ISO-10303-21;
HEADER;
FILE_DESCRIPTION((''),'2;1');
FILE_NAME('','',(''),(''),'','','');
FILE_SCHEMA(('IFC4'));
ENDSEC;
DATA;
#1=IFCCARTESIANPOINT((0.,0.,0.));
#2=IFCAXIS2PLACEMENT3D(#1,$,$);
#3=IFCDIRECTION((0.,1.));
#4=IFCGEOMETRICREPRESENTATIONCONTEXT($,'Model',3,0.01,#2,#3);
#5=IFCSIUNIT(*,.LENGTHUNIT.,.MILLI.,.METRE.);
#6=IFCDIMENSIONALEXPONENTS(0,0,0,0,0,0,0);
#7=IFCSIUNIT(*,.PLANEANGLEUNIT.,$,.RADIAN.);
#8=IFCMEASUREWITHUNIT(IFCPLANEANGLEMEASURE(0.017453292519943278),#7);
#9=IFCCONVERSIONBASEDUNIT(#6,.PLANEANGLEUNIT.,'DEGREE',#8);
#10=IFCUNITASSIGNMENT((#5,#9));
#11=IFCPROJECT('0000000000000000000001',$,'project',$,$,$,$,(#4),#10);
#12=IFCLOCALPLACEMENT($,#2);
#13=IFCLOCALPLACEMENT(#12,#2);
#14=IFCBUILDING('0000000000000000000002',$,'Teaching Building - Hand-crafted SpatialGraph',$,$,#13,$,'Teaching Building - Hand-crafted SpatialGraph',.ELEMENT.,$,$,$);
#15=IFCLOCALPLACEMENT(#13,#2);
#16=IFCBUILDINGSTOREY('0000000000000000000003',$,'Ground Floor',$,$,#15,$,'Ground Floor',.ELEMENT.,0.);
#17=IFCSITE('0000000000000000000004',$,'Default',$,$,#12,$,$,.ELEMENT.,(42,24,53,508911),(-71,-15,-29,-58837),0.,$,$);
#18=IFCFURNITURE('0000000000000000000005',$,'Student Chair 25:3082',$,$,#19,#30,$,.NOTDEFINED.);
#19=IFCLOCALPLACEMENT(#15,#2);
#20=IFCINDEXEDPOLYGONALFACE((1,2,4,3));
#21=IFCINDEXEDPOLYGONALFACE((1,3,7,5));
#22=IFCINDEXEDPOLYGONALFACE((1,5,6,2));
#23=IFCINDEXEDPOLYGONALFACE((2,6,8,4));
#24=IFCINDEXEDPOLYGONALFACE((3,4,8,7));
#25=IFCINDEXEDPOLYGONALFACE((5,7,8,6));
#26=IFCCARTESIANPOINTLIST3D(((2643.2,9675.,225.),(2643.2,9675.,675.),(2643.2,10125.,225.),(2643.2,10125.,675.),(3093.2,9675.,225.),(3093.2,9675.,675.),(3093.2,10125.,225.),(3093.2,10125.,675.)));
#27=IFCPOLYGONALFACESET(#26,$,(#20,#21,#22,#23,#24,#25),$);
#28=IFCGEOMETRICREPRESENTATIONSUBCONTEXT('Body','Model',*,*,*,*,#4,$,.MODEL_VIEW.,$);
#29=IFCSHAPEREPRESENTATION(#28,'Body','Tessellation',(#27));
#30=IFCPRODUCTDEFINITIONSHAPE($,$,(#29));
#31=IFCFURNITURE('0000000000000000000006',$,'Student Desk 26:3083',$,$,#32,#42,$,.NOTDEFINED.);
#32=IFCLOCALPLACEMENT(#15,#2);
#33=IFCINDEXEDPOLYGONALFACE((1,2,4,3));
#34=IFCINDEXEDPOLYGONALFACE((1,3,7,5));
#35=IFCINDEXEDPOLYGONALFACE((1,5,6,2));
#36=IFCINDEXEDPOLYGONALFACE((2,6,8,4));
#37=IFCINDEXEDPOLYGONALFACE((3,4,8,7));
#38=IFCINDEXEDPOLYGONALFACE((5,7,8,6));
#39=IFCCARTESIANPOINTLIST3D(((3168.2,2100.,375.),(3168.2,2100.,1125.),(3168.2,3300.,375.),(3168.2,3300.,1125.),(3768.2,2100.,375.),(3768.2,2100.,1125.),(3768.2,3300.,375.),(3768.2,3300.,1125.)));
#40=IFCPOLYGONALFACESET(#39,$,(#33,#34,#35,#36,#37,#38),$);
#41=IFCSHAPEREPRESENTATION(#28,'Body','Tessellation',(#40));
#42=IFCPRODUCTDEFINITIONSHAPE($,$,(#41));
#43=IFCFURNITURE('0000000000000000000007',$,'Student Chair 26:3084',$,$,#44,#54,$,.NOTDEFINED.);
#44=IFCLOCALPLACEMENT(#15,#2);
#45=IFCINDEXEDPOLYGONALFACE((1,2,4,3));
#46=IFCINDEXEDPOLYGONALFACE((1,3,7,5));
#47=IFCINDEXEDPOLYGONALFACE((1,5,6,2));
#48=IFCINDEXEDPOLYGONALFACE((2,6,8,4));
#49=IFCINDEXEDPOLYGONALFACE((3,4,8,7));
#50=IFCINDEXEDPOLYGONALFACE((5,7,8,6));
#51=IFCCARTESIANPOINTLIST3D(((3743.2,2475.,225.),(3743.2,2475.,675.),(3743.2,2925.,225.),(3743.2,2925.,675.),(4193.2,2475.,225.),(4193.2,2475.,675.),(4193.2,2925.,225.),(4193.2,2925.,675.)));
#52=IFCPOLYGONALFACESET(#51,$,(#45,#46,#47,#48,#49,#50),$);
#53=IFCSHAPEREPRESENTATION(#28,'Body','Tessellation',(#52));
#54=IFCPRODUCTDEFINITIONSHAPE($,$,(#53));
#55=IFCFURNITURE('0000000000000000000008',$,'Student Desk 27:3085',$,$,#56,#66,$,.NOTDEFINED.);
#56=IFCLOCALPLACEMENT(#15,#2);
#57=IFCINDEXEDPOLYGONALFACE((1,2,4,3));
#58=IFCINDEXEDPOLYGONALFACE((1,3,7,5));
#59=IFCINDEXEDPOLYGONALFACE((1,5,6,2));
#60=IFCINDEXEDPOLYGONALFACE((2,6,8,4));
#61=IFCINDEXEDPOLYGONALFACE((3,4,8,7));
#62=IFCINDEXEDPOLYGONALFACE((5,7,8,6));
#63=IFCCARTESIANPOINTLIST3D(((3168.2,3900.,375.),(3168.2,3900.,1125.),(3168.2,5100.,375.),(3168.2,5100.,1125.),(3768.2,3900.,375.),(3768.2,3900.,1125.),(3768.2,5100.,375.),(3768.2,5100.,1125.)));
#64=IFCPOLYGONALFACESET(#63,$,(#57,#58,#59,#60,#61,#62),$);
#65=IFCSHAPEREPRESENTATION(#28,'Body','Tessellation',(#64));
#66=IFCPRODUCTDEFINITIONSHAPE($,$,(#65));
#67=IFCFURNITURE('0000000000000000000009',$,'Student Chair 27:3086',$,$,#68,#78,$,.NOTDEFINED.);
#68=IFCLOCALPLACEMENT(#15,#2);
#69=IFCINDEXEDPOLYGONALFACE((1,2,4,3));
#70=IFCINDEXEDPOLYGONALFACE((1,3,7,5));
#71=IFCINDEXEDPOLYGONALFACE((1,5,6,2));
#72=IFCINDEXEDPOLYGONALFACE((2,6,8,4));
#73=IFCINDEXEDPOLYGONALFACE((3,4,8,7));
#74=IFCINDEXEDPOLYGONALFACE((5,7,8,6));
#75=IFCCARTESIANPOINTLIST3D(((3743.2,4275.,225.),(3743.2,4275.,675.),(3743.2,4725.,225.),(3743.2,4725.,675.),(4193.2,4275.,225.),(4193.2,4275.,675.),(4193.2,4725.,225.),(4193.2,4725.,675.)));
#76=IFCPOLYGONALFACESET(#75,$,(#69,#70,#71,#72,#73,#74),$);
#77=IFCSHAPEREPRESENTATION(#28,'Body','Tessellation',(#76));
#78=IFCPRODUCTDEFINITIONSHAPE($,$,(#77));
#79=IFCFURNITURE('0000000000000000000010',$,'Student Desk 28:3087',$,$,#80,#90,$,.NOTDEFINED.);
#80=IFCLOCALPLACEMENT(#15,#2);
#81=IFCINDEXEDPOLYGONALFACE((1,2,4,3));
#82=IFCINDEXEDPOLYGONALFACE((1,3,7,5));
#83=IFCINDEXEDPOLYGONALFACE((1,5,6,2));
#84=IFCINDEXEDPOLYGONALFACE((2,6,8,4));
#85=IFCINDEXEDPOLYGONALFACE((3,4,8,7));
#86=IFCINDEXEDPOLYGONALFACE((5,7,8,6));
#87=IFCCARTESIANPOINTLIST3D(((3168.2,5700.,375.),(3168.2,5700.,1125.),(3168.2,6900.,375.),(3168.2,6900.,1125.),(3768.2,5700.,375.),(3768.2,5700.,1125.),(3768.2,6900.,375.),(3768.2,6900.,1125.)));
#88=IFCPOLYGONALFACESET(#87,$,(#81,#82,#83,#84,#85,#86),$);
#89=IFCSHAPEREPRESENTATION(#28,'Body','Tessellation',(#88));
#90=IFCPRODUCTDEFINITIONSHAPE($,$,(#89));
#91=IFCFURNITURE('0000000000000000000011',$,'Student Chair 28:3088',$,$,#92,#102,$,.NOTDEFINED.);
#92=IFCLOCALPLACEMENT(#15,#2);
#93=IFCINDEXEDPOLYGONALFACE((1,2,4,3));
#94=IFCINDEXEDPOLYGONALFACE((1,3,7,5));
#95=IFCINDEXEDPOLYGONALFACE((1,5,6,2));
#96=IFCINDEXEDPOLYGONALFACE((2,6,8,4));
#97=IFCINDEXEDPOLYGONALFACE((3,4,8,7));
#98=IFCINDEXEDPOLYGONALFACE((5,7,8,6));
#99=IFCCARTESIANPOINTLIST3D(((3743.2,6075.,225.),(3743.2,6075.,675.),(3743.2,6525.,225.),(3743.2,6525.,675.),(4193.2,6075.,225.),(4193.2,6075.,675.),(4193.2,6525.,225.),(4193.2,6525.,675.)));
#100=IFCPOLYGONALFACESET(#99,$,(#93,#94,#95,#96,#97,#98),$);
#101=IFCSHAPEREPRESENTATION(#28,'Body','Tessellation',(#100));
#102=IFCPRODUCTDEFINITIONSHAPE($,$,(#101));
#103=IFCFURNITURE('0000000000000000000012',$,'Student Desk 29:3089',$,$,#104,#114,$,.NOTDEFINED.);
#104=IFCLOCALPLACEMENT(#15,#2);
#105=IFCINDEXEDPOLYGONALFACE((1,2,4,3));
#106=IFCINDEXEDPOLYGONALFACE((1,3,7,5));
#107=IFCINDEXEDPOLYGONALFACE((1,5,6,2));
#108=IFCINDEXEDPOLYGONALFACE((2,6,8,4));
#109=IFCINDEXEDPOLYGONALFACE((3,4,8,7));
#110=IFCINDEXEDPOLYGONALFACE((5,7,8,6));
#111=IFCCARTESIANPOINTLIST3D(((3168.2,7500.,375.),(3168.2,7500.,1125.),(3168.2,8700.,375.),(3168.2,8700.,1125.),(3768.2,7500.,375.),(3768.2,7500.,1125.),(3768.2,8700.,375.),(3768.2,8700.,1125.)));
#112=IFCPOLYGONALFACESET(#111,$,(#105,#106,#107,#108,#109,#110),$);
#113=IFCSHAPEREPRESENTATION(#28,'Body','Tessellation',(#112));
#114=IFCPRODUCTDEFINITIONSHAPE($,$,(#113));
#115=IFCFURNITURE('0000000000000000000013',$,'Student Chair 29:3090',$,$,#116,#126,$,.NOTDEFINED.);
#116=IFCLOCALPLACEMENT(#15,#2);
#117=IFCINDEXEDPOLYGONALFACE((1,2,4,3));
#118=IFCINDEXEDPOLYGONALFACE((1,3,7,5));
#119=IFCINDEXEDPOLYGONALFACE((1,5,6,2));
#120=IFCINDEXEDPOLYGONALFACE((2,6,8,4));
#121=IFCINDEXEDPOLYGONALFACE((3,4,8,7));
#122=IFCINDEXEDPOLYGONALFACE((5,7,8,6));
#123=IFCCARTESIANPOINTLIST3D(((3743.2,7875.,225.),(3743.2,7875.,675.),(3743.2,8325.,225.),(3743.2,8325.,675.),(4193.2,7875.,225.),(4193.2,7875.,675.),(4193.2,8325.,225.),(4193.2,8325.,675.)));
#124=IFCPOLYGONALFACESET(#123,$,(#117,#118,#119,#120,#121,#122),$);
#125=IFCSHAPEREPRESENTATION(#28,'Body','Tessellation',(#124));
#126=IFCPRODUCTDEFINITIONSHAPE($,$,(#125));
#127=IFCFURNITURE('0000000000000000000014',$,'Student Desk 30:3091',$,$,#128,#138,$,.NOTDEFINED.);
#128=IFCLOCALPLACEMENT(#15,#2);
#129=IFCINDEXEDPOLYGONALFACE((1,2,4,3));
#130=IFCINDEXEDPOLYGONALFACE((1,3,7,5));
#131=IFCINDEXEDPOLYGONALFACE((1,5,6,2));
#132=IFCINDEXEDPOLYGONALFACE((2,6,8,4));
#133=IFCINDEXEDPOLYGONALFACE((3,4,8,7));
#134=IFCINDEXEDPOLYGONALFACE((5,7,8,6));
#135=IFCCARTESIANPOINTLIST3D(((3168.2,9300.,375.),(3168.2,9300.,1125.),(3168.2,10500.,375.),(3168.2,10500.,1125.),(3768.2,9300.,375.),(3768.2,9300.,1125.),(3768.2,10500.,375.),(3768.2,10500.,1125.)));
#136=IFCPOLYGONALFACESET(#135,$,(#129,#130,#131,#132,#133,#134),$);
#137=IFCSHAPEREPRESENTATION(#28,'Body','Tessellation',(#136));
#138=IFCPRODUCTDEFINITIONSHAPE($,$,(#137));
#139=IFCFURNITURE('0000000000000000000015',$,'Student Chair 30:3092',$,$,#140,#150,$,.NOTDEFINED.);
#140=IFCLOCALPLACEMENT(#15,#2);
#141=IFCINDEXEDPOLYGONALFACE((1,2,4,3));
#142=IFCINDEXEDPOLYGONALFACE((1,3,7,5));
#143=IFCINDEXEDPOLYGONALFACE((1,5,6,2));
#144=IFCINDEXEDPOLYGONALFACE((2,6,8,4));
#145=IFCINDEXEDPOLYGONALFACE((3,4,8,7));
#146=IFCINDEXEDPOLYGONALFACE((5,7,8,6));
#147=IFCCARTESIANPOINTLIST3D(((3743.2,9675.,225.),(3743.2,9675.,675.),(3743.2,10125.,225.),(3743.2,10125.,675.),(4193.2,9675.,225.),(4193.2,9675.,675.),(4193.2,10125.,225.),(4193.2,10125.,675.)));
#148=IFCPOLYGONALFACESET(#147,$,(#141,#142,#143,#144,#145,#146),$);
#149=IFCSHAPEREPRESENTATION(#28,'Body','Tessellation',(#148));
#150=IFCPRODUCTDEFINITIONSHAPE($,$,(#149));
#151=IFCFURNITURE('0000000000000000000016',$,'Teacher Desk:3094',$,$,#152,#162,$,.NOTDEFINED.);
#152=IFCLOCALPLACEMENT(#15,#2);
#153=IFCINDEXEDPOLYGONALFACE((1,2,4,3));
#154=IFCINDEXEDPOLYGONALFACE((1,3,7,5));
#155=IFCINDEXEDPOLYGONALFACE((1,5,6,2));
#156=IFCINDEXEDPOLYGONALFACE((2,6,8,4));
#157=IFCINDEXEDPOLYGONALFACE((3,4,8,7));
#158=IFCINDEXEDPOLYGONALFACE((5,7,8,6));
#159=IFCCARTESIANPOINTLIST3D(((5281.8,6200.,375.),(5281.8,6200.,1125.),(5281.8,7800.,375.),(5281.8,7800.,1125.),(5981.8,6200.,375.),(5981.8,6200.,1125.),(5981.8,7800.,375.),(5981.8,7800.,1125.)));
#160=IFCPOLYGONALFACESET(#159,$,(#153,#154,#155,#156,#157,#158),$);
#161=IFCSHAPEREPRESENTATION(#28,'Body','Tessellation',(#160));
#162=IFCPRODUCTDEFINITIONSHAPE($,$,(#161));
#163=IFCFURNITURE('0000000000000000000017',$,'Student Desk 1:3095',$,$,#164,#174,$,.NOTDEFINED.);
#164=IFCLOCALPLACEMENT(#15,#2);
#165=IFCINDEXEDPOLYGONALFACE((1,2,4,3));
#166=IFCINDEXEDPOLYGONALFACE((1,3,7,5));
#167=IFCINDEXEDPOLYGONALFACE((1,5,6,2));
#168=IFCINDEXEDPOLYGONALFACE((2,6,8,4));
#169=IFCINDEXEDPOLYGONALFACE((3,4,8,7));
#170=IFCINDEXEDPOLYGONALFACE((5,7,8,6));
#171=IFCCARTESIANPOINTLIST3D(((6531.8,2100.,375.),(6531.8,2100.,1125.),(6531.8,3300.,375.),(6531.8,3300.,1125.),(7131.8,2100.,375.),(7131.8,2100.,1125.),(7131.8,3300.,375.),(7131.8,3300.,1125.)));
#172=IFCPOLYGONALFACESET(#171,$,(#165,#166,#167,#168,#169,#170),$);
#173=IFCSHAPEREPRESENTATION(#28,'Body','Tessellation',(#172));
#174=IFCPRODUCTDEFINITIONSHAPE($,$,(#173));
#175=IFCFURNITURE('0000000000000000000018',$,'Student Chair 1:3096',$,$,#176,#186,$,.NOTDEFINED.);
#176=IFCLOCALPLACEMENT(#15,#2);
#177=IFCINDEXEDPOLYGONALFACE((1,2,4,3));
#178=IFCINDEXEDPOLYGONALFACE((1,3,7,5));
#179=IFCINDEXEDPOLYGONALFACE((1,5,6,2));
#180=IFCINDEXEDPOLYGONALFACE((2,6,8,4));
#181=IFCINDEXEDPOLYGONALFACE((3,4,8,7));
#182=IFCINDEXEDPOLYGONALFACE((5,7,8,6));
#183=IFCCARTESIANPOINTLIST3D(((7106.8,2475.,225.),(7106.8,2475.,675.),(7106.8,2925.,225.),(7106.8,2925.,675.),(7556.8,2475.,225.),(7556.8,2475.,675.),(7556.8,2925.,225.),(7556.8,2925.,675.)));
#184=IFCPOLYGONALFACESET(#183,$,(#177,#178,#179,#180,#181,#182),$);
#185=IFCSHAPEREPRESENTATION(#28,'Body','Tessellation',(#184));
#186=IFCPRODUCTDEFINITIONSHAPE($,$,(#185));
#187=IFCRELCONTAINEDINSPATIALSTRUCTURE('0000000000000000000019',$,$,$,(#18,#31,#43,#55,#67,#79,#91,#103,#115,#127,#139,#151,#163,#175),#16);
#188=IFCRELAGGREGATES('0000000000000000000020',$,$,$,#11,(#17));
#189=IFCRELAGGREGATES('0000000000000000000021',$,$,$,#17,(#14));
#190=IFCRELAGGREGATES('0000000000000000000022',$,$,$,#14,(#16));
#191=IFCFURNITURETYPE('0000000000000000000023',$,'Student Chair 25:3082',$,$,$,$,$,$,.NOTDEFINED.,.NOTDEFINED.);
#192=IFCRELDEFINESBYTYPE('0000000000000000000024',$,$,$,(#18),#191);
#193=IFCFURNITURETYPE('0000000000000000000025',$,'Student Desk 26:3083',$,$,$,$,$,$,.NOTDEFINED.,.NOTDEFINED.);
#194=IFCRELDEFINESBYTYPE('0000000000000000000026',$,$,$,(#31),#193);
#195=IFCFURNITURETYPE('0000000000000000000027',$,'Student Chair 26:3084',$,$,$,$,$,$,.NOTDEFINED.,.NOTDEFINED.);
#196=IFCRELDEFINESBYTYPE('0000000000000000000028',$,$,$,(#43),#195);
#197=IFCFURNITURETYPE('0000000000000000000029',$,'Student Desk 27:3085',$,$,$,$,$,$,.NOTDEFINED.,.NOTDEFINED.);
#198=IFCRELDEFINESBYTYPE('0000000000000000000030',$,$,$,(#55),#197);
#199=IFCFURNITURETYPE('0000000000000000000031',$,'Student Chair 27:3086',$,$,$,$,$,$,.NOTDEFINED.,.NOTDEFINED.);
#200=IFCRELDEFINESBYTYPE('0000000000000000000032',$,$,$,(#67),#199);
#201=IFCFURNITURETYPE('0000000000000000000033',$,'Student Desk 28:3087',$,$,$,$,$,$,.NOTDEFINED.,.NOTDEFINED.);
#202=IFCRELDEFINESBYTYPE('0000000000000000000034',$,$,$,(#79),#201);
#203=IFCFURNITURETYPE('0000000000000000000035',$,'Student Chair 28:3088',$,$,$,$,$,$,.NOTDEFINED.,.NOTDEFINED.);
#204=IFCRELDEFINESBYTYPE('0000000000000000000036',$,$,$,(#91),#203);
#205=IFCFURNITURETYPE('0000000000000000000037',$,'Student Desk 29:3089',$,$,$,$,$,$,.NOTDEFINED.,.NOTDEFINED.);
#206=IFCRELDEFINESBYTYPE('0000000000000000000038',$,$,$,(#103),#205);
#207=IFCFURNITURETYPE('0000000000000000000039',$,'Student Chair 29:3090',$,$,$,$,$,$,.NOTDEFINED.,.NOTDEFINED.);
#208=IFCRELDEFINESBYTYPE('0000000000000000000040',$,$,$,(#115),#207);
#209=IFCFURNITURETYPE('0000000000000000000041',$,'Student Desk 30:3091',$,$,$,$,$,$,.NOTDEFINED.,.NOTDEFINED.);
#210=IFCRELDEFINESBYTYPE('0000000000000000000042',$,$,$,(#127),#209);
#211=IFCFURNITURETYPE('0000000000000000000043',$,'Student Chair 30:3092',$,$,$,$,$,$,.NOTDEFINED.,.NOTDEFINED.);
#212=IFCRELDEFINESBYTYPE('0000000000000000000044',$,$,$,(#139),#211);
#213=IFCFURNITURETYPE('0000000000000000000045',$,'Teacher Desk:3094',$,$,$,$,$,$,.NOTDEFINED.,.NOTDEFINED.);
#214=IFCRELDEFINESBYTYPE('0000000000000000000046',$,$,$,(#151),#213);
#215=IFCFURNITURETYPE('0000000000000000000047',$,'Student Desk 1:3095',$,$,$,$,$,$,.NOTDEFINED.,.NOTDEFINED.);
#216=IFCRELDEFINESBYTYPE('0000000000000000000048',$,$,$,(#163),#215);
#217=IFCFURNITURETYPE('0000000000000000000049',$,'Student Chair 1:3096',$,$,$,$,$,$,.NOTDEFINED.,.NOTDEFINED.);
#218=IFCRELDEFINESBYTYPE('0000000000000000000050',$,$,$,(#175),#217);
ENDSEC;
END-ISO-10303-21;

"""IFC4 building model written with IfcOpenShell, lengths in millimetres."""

from ifc_helpers import new_model, entity, si_unit, converted_unit, direction, frame, frame_2d, origin, origin_2d_with_axis, place, context, subcontext, project, spatial, rectangle, extrude, type_object, element, save


model = new_model("IFC4")

# Units and contexts
model_context = context("Model", 3, precision=0.01, world=origin(), true_north=direction((0.0, 1.0)))
body_context = subcontext(model_context, "Body", "Model", "MODEL_VIEW")
ifc_project = project(units=[si_unit("LENGTHUNIT", "METRE", prefix="MILLI"), converted_unit("PLANEANGLEUNIT", "DEGREE", entity("IfcPlaneAngleMeasure", 0.017453292519943278), si_unit("PLANEANGLEUNIT", "RADIAN"), dimensions=[0, 0, 0, 0, 0, 0, 0])], contexts=[model_context])

# Site, building, storey
site_placement = place(None, origin())
site = spatial("IfcSite", under=ifc_project, at=site_placement, Name="Default", CompositionType="ELEMENT", RefLatitude=(42, 24, 53, 508911), RefLongitude=(-71, -15, -29, -58837), RefElevation=0.0)
building_placement = place(site_placement, origin())
building = spatial("IfcBuilding", under=site, at=building_placement, Name="Teaching Building - Hand-crafted SpatialGraph", LongName="Teaching Building - Hand-crafted SpatialGraph", CompositionType="ELEMENT")
storey_placement = place(building_placement, origin())
storey = spatial("IfcBuildingStorey", under=building, at=storey_placement, Name="Ground Floor", LongName="Ground Floor", CompositionType="ELEMENT", Elevation=0.0)

# Furniture
furniture_type_1 = type_object("IfcFurnitureType", Name="Student Chair 25:3082", PredefinedType="NOTDEFINED")
furniture_1_placement = place(storey_placement, origin())
element("IfcFurniture", 1, at=furniture_1_placement, inside=storey, type_object=furniture_type_1, Name="Student Chair 25:3082", PredefinedType="NOTDEFINED", context=body_context, shape_type="SweptSolid", body=[
    extrude(rectangle(XDim=450.0, YDim=450.0, at=frame_2d((0.0, 0.0), x_axis=(1.0, 0.0))), frame((2868.2, 9900.0, 225.0)), (0.0, 0.0, 1.0), 450.0),
])
furniture_type_2 = type_object("IfcFurnitureType", Name="Student Desk 26:3083", PredefinedType="NOTDEFINED")
furniture_2_placement = place(storey_placement, origin())
element("IfcFurniture", 2, at=furniture_2_placement, inside=storey, type_object=furniture_type_2, Name="Student Desk 26:3083", PredefinedType="NOTDEFINED", context=body_context, shape_type="SweptSolid", body=[
    extrude(rectangle(XDim=1200.0, YDim=600.0, at=origin_2d_with_axis()), frame((3468.2, 2700.0, 375.0), z_axis=(0.0, 0.0, 1.0), x_axis=(0.0, 1.0, 0.0)), (0.0, 0.0, 1.0), 750.0),
])
furniture_type_3 = type_object("IfcFurnitureType", Name="Student Chair 26:3084", PredefinedType="NOTDEFINED")
furniture_3_placement = place(storey_placement, origin())
element("IfcFurniture", 3, at=furniture_3_placement, inside=storey, type_object=furniture_type_3, Name="Student Chair 26:3084", PredefinedType="NOTDEFINED", context=body_context, shape_type="SweptSolid", body=[
    extrude(rectangle(XDim=450.0, YDim=450.0, at=frame_2d((0.0, 0.0), x_axis=(1.0, 0.0))), frame((3968.2, 2700.0, 225.0)), (0.0, 0.0, 1.0), 450.0),
])
furniture_type_4 = type_object("IfcFurnitureType", Name="Student Desk 27:3085", PredefinedType="NOTDEFINED")
furniture_4_placement = place(storey_placement, origin())
element("IfcFurniture", 4, at=furniture_4_placement, inside=storey, type_object=furniture_type_4, Name="Student Desk 27:3085", PredefinedType="NOTDEFINED", context=body_context, shape_type="SweptSolid", body=[
    extrude(rectangle(XDim=1200.0, YDim=600.0, at=frame_2d((0.0, 0.0), x_axis=(1.0, 0.0))), frame((3468.2, 4500.0, 375.0), z_axis=(0.0, 0.0, 1.0), x_axis=(0.0, 1.0, 0.0)), (0.0, 0.0, 1.0), 750.0),
])
furniture_type_5 = type_object("IfcFurnitureType", Name="Student Chair 27:3086", PredefinedType="NOTDEFINED")
furniture_5_placement = place(storey_placement, origin())
element("IfcFurniture", 5, at=furniture_5_placement, inside=storey, type_object=furniture_type_5, Name="Student Chair 27:3086", PredefinedType="NOTDEFINED", context=body_context, shape_type="SweptSolid", body=[
    extrude(rectangle(XDim=450.0, YDim=450.0, at=frame_2d((0.0, 0.0), x_axis=(1.0, 0.0))), frame((3968.2, 4500.0, 225.0)), (0.0, 0.0, 1.0), 450.0),
])
furniture_type_6 = type_object("IfcFurnitureType", Name="Student Desk 28:3087", PredefinedType="NOTDEFINED")
furniture_6_placement = place(storey_placement, origin())
element("IfcFurniture", 6, at=furniture_6_placement, inside=storey, type_object=furniture_type_6, Name="Student Desk 28:3087", PredefinedType="NOTDEFINED", context=body_context, shape_type="SweptSolid", body=[
    extrude(rectangle(XDim=1200.0, YDim=600.0, at=origin_2d_with_axis()), frame((3468.2, 6300.0, 375.0), z_axis=(0.0, 0.0, 1.0), x_axis=(0.0, 1.0, 0.0)), (0.0, 0.0, 1.0), 750.0),
])
furniture_type_7 = type_object("IfcFurnitureType", Name="Student Chair 28:3088", PredefinedType="NOTDEFINED")
furniture_7_placement = place(storey_placement, origin())
element("IfcFurniture", 7, at=furniture_7_placement, inside=storey, type_object=furniture_type_7, Name="Student Chair 28:3088", PredefinedType="NOTDEFINED", context=body_context, shape_type="SweptSolid", body=[
    extrude(rectangle(XDim=450.0, YDim=450.0, at=frame_2d((0.0, 0.0), x_axis=(1.0, 0.0))), frame((3968.2, 6300.0, 225.0)), (0.0, 0.0, 1.0), 450.0),
])
furniture_type_8 = type_object("IfcFurnitureType", Name="Student Desk 29:3089", PredefinedType="NOTDEFINED")
furniture_8_placement = place(storey_placement, origin())
element("IfcFurniture", 8, at=furniture_8_placement, inside=storey, type_object=furniture_type_8, Name="Student Desk 29:3089", PredefinedType="NOTDEFINED", context=body_context, shape_type="SweptSolid", body=[
    extrude(rectangle(XDim=1200.0, YDim=600.0, at=origin_2d_with_axis()), frame((3468.2, 8100.0, 375.0), z_axis=(0.0, 0.0, 1.0), x_axis=(0.0, 1.0, 0.0)), (0.0, 0.0, 1.0), 750.0),
])
furniture_type_9 = type_object("IfcFurnitureType", Name="Student Chair 29:3090", PredefinedType="NOTDEFINED")
furniture_9_placement = place(storey_placement, origin())
element("IfcFurniture", 9, at=furniture_9_placement, inside=storey, type_object=furniture_type_9, Name="Student Chair 29:3090", PredefinedType="NOTDEFINED", context=body_context, shape_type="SweptSolid", body=[
    extrude(rectangle(XDim=450.0, YDim=450.0, at=frame_2d((0.0, 0.0), x_axis=(1.0, 0.0))), frame((3968.2, 8100.0, 225.0)), (0.0, 0.0, 1.0), 450.0),
])
furniture_type_10 = type_object("IfcFurnitureType", Name="Student Desk 30:3091", PredefinedType="NOTDEFINED")
furniture_10_placement = place(storey_placement, origin())
element("IfcFurniture", 10, at=furniture_10_placement, inside=storey, type_object=furniture_type_10, Name="Student Desk 30:3091", PredefinedType="NOTDEFINED", context=body_context, shape_type="SweptSolid", body=[
    extrude(rectangle(XDim=1200.0, YDim=600.0, at=origin_2d_with_axis()), frame((3468.2, 9900.0, 375.0), z_axis=(0.0, 0.0, 1.0), x_axis=(0.0, 1.0, 0.0)), (0.0, 0.0, 1.0), 750.0),
])
furniture_type_11 = type_object("IfcFurnitureType", Name="Student Chair 30:3092", PredefinedType="NOTDEFINED")
furniture_11_placement = place(storey_placement, origin())
element("IfcFurniture", 11, at=furniture_11_placement, inside=storey, type_object=furniture_type_11, Name="Student Chair 30:3092", PredefinedType="NOTDEFINED", context=body_context, shape_type="SweptSolid", body=[
    extrude(rectangle(XDim=450.0, YDim=450.0, at=frame_2d((0.0, 0.0), x_axis=(1.0, 0.0))), frame((3968.2, 9900.0, 225.0)), (0.0, 0.0, 1.0), 450.0),
])
furniture_type_12 = type_object("IfcFurnitureType", Name="Teacher Desk:3094", PredefinedType="NOTDEFINED")
furniture_12_placement = place(storey_placement, origin())
element("IfcFurniture", 12, at=furniture_12_placement, inside=storey, type_object=furniture_type_12, Name="Teacher Desk:3094", PredefinedType="NOTDEFINED", context=body_context, shape_type="SweptSolid", body=[
    extrude(rectangle(XDim=1600.0, YDim=700.0, at=origin_2d_with_axis()), frame((5631.8, 7000.0, 375.0), z_axis=(0.0, 0.0, 1.0), x_axis=(0.0, 1.0, 0.0)), (0.0, 0.0, 1.0), 750.0),
])
furniture_type_13 = type_object("IfcFurnitureType", Name="Student Desk 1:3095", PredefinedType="NOTDEFINED")
furniture_13_placement = place(storey_placement, origin())
element("IfcFurniture", 13, at=furniture_13_placement, inside=storey, type_object=furniture_type_13, Name="Student Desk 1:3095", PredefinedType="NOTDEFINED", context=body_context, shape_type="SweptSolid", body=[
    extrude(rectangle(XDim=1200.0, YDim=600.0, at=origin_2d_with_axis()), frame((6831.8, 2700.0, 375.0), z_axis=(0.0, 0.0, 1.0), x_axis=(0.0, 1.0, 0.0)), (0.0, 0.0, 1.0), 750.0),
])
furniture_type_14 = type_object("IfcFurnitureType", Name="Student Chair 1:3096", PredefinedType="NOTDEFINED")
furniture_14_placement = place(storey_placement, origin())
element("IfcFurniture", 14, at=furniture_14_placement, inside=storey, type_object=furniture_type_14, Name="Student Chair 1:3096", PredefinedType="NOTDEFINED", context=body_context, shape_type="SweptSolid", body=[
    extrude(rectangle(XDim=450.0, YDim=450.0, at=frame_2d((0.0, 0.0), x_axis=(1.0, 0.0))), frame((7331.8, 2700.0, 225.0)), (0.0, 0.0, 1.0), 450.0),
])

save(model, "model.ifc")
